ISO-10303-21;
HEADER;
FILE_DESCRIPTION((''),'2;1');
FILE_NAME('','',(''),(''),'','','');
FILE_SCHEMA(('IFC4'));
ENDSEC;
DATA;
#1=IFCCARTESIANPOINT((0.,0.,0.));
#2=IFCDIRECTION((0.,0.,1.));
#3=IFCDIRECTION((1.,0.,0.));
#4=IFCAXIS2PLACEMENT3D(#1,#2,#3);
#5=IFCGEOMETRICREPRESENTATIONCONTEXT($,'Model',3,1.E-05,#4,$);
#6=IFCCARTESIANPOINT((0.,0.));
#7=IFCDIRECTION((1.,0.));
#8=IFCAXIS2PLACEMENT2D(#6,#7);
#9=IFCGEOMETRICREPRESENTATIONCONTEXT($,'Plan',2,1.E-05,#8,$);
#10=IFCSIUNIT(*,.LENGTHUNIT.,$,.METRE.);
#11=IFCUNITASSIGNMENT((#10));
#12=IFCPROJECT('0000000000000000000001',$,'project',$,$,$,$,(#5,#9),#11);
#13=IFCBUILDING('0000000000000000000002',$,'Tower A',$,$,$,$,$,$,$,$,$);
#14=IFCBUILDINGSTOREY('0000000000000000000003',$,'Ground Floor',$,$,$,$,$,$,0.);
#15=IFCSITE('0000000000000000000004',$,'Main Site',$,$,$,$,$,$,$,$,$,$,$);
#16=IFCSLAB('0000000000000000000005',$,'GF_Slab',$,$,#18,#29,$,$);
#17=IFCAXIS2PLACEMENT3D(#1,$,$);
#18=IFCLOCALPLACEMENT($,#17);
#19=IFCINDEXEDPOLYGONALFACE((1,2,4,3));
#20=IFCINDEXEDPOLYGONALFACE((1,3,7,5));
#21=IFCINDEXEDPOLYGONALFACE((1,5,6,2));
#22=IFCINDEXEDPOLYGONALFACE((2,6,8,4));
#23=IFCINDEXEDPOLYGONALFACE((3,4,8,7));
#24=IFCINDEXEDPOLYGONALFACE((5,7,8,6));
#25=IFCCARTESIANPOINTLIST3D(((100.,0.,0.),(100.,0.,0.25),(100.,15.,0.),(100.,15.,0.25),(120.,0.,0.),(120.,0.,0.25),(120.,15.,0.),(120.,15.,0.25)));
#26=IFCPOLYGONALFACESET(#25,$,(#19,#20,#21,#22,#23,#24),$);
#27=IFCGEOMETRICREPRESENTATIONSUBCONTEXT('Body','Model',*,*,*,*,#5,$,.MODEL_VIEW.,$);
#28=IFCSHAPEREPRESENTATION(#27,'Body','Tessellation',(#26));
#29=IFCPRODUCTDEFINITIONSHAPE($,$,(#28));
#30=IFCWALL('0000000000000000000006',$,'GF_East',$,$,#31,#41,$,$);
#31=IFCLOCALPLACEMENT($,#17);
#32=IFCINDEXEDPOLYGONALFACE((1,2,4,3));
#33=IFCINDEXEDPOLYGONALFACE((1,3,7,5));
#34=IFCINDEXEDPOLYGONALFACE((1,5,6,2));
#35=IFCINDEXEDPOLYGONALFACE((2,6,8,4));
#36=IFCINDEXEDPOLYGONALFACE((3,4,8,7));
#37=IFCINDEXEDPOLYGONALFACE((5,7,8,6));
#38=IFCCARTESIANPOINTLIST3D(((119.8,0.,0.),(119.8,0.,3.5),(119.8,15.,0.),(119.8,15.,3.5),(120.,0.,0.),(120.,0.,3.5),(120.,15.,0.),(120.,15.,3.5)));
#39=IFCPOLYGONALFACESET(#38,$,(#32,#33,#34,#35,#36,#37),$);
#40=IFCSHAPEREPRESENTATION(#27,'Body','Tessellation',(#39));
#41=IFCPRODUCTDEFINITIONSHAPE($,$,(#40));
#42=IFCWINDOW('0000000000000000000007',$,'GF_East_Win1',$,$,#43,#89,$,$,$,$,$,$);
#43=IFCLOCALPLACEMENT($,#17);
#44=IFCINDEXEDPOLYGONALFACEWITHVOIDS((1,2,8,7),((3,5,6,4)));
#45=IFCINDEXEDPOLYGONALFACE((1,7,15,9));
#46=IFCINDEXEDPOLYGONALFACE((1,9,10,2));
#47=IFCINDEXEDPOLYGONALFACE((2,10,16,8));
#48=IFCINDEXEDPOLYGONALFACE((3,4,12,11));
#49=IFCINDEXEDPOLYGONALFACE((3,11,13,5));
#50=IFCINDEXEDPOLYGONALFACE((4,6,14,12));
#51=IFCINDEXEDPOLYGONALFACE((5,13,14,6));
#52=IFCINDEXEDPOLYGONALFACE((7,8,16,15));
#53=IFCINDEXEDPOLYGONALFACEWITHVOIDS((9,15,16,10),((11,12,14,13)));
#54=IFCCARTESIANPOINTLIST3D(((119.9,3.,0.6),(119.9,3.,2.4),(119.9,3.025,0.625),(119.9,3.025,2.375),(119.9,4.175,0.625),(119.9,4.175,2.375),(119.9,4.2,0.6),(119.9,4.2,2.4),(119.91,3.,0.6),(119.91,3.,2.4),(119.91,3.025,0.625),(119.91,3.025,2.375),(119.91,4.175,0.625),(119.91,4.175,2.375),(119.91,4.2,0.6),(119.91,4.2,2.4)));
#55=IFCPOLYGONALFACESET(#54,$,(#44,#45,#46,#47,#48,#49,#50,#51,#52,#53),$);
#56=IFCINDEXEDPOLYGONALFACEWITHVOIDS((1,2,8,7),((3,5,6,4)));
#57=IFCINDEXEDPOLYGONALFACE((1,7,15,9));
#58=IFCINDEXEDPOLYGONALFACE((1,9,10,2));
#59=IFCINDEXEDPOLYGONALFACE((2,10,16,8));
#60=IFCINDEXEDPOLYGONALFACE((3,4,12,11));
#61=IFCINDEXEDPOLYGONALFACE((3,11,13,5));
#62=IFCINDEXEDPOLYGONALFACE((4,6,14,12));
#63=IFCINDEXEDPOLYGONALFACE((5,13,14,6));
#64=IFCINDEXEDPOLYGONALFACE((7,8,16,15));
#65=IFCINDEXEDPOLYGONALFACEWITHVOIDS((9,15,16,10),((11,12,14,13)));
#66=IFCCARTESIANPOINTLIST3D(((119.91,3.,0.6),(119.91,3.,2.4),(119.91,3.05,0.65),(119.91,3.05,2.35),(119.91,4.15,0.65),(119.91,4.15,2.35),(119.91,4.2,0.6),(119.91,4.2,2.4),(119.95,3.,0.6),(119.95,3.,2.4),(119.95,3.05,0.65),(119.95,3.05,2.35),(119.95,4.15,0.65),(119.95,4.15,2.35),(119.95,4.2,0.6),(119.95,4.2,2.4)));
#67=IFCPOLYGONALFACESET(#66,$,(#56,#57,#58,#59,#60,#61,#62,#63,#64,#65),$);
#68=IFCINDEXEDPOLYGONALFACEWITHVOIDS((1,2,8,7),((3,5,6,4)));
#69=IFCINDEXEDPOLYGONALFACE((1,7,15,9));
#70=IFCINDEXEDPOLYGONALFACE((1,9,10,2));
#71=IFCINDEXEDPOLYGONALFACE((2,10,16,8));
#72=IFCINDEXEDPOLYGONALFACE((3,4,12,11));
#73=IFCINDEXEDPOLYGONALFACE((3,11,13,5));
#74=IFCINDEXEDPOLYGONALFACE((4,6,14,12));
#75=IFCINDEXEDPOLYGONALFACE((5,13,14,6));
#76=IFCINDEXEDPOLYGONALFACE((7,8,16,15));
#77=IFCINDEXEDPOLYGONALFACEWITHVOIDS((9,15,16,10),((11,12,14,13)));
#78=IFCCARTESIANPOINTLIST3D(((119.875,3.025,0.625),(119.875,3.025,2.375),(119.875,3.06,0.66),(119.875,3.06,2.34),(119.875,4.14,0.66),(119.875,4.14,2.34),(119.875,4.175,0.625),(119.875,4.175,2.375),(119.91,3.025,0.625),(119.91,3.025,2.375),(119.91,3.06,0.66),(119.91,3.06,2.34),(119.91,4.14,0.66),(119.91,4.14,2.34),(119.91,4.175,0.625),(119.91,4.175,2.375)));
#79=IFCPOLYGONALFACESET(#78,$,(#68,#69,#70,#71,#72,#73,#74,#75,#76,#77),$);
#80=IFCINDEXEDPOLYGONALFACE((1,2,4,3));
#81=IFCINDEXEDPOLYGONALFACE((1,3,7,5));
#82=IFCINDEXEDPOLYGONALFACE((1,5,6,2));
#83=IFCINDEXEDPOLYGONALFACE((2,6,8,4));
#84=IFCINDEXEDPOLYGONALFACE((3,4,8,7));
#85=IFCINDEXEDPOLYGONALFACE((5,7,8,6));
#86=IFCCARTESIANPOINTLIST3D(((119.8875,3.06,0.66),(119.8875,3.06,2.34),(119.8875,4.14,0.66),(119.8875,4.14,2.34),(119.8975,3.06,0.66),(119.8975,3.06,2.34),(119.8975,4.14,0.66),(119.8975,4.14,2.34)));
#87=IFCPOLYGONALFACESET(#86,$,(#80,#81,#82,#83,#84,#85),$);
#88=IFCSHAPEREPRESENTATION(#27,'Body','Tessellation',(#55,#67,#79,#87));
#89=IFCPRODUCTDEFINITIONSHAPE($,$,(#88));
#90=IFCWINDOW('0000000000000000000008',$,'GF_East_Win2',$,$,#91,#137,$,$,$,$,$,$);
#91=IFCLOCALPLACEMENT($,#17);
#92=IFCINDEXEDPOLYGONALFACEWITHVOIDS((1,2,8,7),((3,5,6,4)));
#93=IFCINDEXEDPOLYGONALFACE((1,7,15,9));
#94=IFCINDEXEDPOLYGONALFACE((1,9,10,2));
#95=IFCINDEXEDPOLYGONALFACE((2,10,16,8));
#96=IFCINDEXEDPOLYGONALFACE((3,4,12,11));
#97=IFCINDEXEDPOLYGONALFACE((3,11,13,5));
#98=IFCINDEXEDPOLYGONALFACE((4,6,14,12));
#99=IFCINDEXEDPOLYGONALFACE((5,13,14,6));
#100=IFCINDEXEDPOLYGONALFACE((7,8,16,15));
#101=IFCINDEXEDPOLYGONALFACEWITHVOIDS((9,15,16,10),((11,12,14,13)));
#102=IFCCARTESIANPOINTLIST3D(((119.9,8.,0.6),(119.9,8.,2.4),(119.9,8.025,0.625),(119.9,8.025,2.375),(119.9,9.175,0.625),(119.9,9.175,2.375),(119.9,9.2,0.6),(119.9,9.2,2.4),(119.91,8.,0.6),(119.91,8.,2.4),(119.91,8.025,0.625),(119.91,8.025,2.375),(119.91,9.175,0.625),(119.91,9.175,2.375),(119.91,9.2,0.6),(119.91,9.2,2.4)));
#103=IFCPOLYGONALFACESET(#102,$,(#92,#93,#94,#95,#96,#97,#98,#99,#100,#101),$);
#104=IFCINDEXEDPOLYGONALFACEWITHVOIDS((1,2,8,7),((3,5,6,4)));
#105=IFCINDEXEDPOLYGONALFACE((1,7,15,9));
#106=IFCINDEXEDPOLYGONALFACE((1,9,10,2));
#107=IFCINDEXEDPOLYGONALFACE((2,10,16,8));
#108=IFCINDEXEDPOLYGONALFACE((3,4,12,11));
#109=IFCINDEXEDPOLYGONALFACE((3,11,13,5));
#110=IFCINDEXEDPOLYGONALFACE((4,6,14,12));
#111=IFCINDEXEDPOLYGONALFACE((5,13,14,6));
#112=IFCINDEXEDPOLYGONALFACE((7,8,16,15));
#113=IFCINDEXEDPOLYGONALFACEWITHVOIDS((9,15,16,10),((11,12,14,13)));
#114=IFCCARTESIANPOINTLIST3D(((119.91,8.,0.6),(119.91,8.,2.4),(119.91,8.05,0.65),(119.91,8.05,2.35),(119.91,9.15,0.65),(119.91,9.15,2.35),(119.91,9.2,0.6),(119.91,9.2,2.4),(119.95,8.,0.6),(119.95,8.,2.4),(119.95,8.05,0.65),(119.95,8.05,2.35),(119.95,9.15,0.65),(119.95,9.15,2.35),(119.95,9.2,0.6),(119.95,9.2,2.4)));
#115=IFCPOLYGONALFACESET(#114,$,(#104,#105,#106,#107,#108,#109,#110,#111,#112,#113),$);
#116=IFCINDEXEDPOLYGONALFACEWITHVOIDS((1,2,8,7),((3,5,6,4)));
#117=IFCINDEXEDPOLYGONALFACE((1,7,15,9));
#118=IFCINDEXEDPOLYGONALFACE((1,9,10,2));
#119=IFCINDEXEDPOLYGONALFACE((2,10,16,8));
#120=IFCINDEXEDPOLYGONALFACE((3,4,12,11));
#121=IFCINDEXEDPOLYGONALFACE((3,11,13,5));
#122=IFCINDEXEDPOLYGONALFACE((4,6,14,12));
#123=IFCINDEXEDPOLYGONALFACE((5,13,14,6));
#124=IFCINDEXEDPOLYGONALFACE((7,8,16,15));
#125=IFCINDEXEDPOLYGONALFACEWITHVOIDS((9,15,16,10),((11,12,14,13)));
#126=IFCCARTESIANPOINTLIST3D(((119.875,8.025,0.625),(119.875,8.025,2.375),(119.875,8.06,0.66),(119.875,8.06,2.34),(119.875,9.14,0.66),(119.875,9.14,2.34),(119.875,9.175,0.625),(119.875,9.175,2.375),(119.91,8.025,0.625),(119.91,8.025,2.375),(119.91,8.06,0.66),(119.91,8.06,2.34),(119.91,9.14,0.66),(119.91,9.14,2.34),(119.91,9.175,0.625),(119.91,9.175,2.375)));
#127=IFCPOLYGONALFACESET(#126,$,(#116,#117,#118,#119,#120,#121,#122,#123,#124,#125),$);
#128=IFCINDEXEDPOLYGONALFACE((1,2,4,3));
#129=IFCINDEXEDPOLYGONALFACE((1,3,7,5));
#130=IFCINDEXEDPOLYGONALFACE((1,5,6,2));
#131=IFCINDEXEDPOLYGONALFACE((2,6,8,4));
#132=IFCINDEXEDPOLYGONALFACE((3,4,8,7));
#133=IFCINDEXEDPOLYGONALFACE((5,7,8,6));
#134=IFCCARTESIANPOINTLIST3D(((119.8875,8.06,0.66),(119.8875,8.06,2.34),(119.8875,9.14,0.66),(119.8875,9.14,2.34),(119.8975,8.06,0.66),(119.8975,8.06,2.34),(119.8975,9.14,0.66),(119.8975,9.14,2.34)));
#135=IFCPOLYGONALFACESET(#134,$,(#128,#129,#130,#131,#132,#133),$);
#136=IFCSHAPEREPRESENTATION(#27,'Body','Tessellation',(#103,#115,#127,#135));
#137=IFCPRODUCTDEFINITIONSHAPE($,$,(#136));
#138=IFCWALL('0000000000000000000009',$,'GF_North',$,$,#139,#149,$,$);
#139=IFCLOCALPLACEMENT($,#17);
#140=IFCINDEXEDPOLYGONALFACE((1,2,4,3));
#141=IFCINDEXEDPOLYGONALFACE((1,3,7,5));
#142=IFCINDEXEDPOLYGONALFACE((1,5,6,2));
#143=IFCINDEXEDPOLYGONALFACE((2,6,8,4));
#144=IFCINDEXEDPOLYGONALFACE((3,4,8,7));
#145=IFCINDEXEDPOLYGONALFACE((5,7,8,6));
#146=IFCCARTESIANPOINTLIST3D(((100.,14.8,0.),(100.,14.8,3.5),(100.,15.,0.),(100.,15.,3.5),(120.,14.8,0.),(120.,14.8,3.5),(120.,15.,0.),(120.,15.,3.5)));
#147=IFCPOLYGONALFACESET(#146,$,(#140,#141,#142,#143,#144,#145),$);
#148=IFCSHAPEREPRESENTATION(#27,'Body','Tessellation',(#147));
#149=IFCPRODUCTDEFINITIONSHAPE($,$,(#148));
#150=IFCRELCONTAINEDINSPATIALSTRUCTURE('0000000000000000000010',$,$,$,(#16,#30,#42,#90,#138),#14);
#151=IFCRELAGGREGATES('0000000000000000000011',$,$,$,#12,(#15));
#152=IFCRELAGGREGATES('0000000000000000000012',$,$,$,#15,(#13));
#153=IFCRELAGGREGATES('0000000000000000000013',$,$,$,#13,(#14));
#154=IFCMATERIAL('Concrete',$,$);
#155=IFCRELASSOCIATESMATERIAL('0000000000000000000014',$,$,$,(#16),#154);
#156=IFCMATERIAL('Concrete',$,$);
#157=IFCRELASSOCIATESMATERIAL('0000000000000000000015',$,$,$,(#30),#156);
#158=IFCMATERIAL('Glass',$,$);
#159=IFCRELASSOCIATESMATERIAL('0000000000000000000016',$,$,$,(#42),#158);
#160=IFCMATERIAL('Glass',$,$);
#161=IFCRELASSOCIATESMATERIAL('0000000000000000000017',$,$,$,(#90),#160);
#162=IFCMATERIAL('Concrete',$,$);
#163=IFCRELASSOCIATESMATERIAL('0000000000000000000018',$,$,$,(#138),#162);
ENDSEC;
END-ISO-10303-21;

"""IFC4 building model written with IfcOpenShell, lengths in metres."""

from ifc_helpers import new_model, si_unit, frame, origin_with_axes, origin_2d_with_axis, place, context, subcontext, project, spatial, line, indexed_curve, outline, extrude, material, element, fill, save


model = new_model("IFC4")

# Units and contexts
model_context = context("Model", 3, precision=1e-05, world=origin_with_axes())
plan_context = context("Plan", 2, precision=1e-05, world=origin_2d_with_axis())
body_context = subcontext(model_context, "Body", "Model", "MODEL_VIEW")
ifc_project = project(units=[si_unit("LENGTHUNIT", "METRE")], contexts=[model_context, plan_context])

# Site, building, storey
site = spatial("IfcSite", under=ifc_project, Name="Main Site")
building = spatial("IfcBuilding", under=site, Name="Tower A")
storey = spatial("IfcBuildingStorey", under=building, Name="Ground Floor", Elevation=0.0)

# Slab
ifc_material_1 = material(Name="Concrete")
slab_placement = place(None, frame((100.0, 0.0, 0.0), z_axis=(0.0, 0.0, 1.0), x_axis=(1.0, 0.0, 0.0)))
element("IfcSlab", 1, at=slab_placement, inside=storey, material=ifc_material_1, Name="GF_Slab", context=body_context, shape_type="SweptSolid", body=[
    extrude(outline(indexed_curve([(0.0, 0.0), (20.0, 0.0), (20.0, 15.0), (0.0, 15.0)])), None, (0.0, 0.0, 1.0), 0.25),
])

# Wall, openings, windows
ifc_material_2 = material(Name="Concrete")
wall_1_placement = place(None, frame((120.0, 0.0, 0.0), z_axis=(0.0, 0.0, 1.0), x_axis=(0.0, 1.0, 0.0)))
wall_1 = element("IfcWall", 2, at=wall_1_placement, inside=storey, material=ifc_material_2, Name="GF_East", context=body_context, shape_type="SweptSolid", body=[
    extrude(outline(indexed_curve([(0.0, 0.0), (0.0, 0.2), (15.0, 0.2), (15.0, 0.0), (0.0, 0.0)], self_intersect=False)), origin_with_axes(), (0.0, 0.0, 1.0), 3.5),
])
opening_1_placement = place(wall_1_placement, frame((3.0, 0.0, 0.6), z_axis=(0.0, 0.0, 1.0), x_axis=(0.0, -1.0, 0.0)))
opening_1 = element("IfcOpeningElement", 3, at=opening_1_placement, cuts=wall_1, context=body_context, shape_type="SweptSolid", body=[
    extrude(outline(indexed_curve([(0.0, 0.0), (0.0, 0.25), (1.2, 0.25), (1.2, 0.0), (0.0, 0.0)], self_intersect=False)), origin_with_axes(), (0.0, 0.0, 1.0), 1.8),
])
opening_2_placement = place(wall_1_placement, frame((8.0, 0.0, 0.6), z_axis=(0.0, 0.0, 1.0), x_axis=(0.0, -1.0, 0.0)))
opening_2 = element("IfcOpeningElement", 4, at=opening_2_placement, cuts=wall_1, context=body_context, shape_type="SweptSolid", body=[
    extrude(outline(indexed_curve([(0.0, 0.0), (0.0, 0.25), (1.2, 0.25), (1.2, 0.0), (0.0, 0.0)], self_intersect=False)), origin_with_axes(), (0.0, 0.0, 1.0), 1.8),
])
ifc_material_3 = material(Name="Glass")
window_1_placement = place(None, frame((120.0, 3.0, 0.6), z_axis=(0.0, 0.0, 1.0), x_axis=(0.0, 1.0, 0.0)))
window_1 = element("IfcWindow", 5, at=window_1_placement, inside=storey, material=ifc_material_3, Name="GF_East_Win1", context=body_context, shape_type="SweptSolid", body=[
    extrude(outline(indexed_curve([(0.0, 0.0), (1.2, 0.0), (1.2, 1.8), (0.0, 1.8)], segments=[line(1, 2, 3, 4, 1)]), holes=[indexed_curve([(0.025, 0.025), (1.175, 0.025), (1.175, 1.775), (0.025, 1.775)], segments=[line(1, 2, 3, 4, 1)])]), frame((0.0, 0.09, 0.0), z_axis=(0.0, -1.0, 0.0), x_axis=(1.0, 0.0, 0.0)), (0.0, 0.0, -1.0), 0.01),
    extrude(outline(indexed_curve([(0.0, 0.0), (1.2, 0.0), (1.2, 1.8), (0.0, 1.8)], segments=[line(1, 2, 3, 4, 1)]), holes=[indexed_curve([(0.05, 0.05), (1.15, 0.05), (1.15, 1.75), (0.05, 1.75)], segments=[line(1, 2, 3, 4, 1)])]), frame((0.0, 0.05, 0.0), z_axis=(0.0, -1.0, 0.0), x_axis=(1.0, 0.0, 0.0)), (0.0, 0.0, -1.0), 0.04),
    extrude(outline(indexed_curve([(0.0, 0.0), (1.15, 0.0), (1.15, 1.75), (0.0, 1.75)], segments=[line(1, 2, 3, 4, 1)]), holes=[indexed_curve([(0.035, 0.035), (1.115, 0.035), (1.115, 1.715), (0.035, 1.715)], segments=[line(1, 2, 3, 4, 1)])]), frame((0.025, 0.09, 0.025), z_axis=(0.0, -1.0, 0.0), x_axis=(1.0, 0.0, 0.0)), (0.0, 0.0, -1.0), 0.035),
    extrude(outline(indexed_curve([(0.035, 0.035), (1.115, 0.035), (1.115, 1.715), (0.035, 1.715)], segments=[line(1, 2, 3, 4, 1)])), frame((0.025, 0.1025, 0.025), z_axis=(0.0, -1.0, 0.0), x_axis=(1.0, 0.0, 0.0)), (0.0, 0.0, -1.0), 0.01),
])
fill(opening_1, window_1)
ifc_material_4 = material(Name="Glass")
window_2_placement = place(None, frame((120.0, 8.0, 0.6), z_axis=(0.0, 0.0, 1.0), x_axis=(0.0, 1.0, 0.0)))
window_2 = element("IfcWindow", 6, at=window_2_placement, inside=storey, material=ifc_material_4, Name="GF_East_Win2", context=body_context, shape_type="SweptSolid", body=[
    extrude(outline(indexed_curve([(0.0, 0.0), (1.2, 0.0), (1.2, 1.8), (0.0, 1.8)], segments=[line(1, 2, 3, 4, 1)]), holes=[indexed_curve([(0.025, 0.025), (1.175, 0.025), (1.175, 1.775), (0.025, 1.775)], segments=[line(1, 2, 3, 4, 1)])]), frame((0.0, 0.09, 0.0), z_axis=(0.0, -1.0, 0.0), x_axis=(1.0, 0.0, 0.0)), (0.0, 0.0, -1.0), 0.01),
    extrude(outline(indexed_curve([(0.0, 0.0), (1.2, 0.0), (1.2, 1.8), (0.0, 1.8)], segments=[line(1, 2, 3, 4, 1)]), holes=[indexed_curve([(0.05, 0.05), (1.15, 0.05), (1.15, 1.75), (0.05, 1.75)], segments=[line(1, 2, 3, 4, 1)])]), frame((0.0, 0.05, 0.0), z_axis=(0.0, -1.0, 0.0), x_axis=(1.0, 0.0, 0.0)), (0.0, 0.0, -1.0), 0.04),
    extrude(outline(indexed_curve([(0.0, 0.0), (1.15, 0.0), (1.15, 1.75), (0.0, 1.75)], segments=[line(1, 2, 3, 4, 1)]), holes=[indexed_curve([(0.035, 0.035), (1.115, 0.035), (1.115, 1.715), (0.035, 1.715)], segments=[line(1, 2, 3, 4, 1)])]), frame((0.025, 0.09, 0.025), z_axis=(0.0, -1.0, 0.0), x_axis=(1.0, 0.0, 0.0)), (0.0, 0.0, -1.0), 0.035),
    extrude(outline(indexed_curve([(0.035, 0.035), (1.115, 0.035), (1.115, 1.715), (0.035, 1.715)], segments=[line(1, 2, 3, 4, 1)])), frame((0.025, 0.1025, 0.025), z_axis=(0.0, -1.0, 0.0), x_axis=(1.0, 0.0, 0.0)), (0.0, 0.0, -1.0), 0.01),
])
fill(opening_2, window_2)

# Wall
ifc_material_5 = material(Name="Concrete")
wall_2_placement = place(None, frame((120.0, 15.0, 0.0), z_axis=(0.0, 0.0, 1.0), x_axis=(-1.0, 0.0, 0.0)))
element("IfcWall", 7, at=wall_2_placement, inside=storey, material=ifc_material_5, Name="GF_North", context=body_context, shape_type="SweptSolid", body=[
    extrude(outline(indexed_curve([(0.0, 0.0), (0.0, 0.2), (20.0, 0.2), (20.0, 0.0), (0.0, 0.0)], self_intersect=False)), origin_with_axes(), (0.0, 0.0, 1.0), 3.5),
])

save(model, "model.ifc")
